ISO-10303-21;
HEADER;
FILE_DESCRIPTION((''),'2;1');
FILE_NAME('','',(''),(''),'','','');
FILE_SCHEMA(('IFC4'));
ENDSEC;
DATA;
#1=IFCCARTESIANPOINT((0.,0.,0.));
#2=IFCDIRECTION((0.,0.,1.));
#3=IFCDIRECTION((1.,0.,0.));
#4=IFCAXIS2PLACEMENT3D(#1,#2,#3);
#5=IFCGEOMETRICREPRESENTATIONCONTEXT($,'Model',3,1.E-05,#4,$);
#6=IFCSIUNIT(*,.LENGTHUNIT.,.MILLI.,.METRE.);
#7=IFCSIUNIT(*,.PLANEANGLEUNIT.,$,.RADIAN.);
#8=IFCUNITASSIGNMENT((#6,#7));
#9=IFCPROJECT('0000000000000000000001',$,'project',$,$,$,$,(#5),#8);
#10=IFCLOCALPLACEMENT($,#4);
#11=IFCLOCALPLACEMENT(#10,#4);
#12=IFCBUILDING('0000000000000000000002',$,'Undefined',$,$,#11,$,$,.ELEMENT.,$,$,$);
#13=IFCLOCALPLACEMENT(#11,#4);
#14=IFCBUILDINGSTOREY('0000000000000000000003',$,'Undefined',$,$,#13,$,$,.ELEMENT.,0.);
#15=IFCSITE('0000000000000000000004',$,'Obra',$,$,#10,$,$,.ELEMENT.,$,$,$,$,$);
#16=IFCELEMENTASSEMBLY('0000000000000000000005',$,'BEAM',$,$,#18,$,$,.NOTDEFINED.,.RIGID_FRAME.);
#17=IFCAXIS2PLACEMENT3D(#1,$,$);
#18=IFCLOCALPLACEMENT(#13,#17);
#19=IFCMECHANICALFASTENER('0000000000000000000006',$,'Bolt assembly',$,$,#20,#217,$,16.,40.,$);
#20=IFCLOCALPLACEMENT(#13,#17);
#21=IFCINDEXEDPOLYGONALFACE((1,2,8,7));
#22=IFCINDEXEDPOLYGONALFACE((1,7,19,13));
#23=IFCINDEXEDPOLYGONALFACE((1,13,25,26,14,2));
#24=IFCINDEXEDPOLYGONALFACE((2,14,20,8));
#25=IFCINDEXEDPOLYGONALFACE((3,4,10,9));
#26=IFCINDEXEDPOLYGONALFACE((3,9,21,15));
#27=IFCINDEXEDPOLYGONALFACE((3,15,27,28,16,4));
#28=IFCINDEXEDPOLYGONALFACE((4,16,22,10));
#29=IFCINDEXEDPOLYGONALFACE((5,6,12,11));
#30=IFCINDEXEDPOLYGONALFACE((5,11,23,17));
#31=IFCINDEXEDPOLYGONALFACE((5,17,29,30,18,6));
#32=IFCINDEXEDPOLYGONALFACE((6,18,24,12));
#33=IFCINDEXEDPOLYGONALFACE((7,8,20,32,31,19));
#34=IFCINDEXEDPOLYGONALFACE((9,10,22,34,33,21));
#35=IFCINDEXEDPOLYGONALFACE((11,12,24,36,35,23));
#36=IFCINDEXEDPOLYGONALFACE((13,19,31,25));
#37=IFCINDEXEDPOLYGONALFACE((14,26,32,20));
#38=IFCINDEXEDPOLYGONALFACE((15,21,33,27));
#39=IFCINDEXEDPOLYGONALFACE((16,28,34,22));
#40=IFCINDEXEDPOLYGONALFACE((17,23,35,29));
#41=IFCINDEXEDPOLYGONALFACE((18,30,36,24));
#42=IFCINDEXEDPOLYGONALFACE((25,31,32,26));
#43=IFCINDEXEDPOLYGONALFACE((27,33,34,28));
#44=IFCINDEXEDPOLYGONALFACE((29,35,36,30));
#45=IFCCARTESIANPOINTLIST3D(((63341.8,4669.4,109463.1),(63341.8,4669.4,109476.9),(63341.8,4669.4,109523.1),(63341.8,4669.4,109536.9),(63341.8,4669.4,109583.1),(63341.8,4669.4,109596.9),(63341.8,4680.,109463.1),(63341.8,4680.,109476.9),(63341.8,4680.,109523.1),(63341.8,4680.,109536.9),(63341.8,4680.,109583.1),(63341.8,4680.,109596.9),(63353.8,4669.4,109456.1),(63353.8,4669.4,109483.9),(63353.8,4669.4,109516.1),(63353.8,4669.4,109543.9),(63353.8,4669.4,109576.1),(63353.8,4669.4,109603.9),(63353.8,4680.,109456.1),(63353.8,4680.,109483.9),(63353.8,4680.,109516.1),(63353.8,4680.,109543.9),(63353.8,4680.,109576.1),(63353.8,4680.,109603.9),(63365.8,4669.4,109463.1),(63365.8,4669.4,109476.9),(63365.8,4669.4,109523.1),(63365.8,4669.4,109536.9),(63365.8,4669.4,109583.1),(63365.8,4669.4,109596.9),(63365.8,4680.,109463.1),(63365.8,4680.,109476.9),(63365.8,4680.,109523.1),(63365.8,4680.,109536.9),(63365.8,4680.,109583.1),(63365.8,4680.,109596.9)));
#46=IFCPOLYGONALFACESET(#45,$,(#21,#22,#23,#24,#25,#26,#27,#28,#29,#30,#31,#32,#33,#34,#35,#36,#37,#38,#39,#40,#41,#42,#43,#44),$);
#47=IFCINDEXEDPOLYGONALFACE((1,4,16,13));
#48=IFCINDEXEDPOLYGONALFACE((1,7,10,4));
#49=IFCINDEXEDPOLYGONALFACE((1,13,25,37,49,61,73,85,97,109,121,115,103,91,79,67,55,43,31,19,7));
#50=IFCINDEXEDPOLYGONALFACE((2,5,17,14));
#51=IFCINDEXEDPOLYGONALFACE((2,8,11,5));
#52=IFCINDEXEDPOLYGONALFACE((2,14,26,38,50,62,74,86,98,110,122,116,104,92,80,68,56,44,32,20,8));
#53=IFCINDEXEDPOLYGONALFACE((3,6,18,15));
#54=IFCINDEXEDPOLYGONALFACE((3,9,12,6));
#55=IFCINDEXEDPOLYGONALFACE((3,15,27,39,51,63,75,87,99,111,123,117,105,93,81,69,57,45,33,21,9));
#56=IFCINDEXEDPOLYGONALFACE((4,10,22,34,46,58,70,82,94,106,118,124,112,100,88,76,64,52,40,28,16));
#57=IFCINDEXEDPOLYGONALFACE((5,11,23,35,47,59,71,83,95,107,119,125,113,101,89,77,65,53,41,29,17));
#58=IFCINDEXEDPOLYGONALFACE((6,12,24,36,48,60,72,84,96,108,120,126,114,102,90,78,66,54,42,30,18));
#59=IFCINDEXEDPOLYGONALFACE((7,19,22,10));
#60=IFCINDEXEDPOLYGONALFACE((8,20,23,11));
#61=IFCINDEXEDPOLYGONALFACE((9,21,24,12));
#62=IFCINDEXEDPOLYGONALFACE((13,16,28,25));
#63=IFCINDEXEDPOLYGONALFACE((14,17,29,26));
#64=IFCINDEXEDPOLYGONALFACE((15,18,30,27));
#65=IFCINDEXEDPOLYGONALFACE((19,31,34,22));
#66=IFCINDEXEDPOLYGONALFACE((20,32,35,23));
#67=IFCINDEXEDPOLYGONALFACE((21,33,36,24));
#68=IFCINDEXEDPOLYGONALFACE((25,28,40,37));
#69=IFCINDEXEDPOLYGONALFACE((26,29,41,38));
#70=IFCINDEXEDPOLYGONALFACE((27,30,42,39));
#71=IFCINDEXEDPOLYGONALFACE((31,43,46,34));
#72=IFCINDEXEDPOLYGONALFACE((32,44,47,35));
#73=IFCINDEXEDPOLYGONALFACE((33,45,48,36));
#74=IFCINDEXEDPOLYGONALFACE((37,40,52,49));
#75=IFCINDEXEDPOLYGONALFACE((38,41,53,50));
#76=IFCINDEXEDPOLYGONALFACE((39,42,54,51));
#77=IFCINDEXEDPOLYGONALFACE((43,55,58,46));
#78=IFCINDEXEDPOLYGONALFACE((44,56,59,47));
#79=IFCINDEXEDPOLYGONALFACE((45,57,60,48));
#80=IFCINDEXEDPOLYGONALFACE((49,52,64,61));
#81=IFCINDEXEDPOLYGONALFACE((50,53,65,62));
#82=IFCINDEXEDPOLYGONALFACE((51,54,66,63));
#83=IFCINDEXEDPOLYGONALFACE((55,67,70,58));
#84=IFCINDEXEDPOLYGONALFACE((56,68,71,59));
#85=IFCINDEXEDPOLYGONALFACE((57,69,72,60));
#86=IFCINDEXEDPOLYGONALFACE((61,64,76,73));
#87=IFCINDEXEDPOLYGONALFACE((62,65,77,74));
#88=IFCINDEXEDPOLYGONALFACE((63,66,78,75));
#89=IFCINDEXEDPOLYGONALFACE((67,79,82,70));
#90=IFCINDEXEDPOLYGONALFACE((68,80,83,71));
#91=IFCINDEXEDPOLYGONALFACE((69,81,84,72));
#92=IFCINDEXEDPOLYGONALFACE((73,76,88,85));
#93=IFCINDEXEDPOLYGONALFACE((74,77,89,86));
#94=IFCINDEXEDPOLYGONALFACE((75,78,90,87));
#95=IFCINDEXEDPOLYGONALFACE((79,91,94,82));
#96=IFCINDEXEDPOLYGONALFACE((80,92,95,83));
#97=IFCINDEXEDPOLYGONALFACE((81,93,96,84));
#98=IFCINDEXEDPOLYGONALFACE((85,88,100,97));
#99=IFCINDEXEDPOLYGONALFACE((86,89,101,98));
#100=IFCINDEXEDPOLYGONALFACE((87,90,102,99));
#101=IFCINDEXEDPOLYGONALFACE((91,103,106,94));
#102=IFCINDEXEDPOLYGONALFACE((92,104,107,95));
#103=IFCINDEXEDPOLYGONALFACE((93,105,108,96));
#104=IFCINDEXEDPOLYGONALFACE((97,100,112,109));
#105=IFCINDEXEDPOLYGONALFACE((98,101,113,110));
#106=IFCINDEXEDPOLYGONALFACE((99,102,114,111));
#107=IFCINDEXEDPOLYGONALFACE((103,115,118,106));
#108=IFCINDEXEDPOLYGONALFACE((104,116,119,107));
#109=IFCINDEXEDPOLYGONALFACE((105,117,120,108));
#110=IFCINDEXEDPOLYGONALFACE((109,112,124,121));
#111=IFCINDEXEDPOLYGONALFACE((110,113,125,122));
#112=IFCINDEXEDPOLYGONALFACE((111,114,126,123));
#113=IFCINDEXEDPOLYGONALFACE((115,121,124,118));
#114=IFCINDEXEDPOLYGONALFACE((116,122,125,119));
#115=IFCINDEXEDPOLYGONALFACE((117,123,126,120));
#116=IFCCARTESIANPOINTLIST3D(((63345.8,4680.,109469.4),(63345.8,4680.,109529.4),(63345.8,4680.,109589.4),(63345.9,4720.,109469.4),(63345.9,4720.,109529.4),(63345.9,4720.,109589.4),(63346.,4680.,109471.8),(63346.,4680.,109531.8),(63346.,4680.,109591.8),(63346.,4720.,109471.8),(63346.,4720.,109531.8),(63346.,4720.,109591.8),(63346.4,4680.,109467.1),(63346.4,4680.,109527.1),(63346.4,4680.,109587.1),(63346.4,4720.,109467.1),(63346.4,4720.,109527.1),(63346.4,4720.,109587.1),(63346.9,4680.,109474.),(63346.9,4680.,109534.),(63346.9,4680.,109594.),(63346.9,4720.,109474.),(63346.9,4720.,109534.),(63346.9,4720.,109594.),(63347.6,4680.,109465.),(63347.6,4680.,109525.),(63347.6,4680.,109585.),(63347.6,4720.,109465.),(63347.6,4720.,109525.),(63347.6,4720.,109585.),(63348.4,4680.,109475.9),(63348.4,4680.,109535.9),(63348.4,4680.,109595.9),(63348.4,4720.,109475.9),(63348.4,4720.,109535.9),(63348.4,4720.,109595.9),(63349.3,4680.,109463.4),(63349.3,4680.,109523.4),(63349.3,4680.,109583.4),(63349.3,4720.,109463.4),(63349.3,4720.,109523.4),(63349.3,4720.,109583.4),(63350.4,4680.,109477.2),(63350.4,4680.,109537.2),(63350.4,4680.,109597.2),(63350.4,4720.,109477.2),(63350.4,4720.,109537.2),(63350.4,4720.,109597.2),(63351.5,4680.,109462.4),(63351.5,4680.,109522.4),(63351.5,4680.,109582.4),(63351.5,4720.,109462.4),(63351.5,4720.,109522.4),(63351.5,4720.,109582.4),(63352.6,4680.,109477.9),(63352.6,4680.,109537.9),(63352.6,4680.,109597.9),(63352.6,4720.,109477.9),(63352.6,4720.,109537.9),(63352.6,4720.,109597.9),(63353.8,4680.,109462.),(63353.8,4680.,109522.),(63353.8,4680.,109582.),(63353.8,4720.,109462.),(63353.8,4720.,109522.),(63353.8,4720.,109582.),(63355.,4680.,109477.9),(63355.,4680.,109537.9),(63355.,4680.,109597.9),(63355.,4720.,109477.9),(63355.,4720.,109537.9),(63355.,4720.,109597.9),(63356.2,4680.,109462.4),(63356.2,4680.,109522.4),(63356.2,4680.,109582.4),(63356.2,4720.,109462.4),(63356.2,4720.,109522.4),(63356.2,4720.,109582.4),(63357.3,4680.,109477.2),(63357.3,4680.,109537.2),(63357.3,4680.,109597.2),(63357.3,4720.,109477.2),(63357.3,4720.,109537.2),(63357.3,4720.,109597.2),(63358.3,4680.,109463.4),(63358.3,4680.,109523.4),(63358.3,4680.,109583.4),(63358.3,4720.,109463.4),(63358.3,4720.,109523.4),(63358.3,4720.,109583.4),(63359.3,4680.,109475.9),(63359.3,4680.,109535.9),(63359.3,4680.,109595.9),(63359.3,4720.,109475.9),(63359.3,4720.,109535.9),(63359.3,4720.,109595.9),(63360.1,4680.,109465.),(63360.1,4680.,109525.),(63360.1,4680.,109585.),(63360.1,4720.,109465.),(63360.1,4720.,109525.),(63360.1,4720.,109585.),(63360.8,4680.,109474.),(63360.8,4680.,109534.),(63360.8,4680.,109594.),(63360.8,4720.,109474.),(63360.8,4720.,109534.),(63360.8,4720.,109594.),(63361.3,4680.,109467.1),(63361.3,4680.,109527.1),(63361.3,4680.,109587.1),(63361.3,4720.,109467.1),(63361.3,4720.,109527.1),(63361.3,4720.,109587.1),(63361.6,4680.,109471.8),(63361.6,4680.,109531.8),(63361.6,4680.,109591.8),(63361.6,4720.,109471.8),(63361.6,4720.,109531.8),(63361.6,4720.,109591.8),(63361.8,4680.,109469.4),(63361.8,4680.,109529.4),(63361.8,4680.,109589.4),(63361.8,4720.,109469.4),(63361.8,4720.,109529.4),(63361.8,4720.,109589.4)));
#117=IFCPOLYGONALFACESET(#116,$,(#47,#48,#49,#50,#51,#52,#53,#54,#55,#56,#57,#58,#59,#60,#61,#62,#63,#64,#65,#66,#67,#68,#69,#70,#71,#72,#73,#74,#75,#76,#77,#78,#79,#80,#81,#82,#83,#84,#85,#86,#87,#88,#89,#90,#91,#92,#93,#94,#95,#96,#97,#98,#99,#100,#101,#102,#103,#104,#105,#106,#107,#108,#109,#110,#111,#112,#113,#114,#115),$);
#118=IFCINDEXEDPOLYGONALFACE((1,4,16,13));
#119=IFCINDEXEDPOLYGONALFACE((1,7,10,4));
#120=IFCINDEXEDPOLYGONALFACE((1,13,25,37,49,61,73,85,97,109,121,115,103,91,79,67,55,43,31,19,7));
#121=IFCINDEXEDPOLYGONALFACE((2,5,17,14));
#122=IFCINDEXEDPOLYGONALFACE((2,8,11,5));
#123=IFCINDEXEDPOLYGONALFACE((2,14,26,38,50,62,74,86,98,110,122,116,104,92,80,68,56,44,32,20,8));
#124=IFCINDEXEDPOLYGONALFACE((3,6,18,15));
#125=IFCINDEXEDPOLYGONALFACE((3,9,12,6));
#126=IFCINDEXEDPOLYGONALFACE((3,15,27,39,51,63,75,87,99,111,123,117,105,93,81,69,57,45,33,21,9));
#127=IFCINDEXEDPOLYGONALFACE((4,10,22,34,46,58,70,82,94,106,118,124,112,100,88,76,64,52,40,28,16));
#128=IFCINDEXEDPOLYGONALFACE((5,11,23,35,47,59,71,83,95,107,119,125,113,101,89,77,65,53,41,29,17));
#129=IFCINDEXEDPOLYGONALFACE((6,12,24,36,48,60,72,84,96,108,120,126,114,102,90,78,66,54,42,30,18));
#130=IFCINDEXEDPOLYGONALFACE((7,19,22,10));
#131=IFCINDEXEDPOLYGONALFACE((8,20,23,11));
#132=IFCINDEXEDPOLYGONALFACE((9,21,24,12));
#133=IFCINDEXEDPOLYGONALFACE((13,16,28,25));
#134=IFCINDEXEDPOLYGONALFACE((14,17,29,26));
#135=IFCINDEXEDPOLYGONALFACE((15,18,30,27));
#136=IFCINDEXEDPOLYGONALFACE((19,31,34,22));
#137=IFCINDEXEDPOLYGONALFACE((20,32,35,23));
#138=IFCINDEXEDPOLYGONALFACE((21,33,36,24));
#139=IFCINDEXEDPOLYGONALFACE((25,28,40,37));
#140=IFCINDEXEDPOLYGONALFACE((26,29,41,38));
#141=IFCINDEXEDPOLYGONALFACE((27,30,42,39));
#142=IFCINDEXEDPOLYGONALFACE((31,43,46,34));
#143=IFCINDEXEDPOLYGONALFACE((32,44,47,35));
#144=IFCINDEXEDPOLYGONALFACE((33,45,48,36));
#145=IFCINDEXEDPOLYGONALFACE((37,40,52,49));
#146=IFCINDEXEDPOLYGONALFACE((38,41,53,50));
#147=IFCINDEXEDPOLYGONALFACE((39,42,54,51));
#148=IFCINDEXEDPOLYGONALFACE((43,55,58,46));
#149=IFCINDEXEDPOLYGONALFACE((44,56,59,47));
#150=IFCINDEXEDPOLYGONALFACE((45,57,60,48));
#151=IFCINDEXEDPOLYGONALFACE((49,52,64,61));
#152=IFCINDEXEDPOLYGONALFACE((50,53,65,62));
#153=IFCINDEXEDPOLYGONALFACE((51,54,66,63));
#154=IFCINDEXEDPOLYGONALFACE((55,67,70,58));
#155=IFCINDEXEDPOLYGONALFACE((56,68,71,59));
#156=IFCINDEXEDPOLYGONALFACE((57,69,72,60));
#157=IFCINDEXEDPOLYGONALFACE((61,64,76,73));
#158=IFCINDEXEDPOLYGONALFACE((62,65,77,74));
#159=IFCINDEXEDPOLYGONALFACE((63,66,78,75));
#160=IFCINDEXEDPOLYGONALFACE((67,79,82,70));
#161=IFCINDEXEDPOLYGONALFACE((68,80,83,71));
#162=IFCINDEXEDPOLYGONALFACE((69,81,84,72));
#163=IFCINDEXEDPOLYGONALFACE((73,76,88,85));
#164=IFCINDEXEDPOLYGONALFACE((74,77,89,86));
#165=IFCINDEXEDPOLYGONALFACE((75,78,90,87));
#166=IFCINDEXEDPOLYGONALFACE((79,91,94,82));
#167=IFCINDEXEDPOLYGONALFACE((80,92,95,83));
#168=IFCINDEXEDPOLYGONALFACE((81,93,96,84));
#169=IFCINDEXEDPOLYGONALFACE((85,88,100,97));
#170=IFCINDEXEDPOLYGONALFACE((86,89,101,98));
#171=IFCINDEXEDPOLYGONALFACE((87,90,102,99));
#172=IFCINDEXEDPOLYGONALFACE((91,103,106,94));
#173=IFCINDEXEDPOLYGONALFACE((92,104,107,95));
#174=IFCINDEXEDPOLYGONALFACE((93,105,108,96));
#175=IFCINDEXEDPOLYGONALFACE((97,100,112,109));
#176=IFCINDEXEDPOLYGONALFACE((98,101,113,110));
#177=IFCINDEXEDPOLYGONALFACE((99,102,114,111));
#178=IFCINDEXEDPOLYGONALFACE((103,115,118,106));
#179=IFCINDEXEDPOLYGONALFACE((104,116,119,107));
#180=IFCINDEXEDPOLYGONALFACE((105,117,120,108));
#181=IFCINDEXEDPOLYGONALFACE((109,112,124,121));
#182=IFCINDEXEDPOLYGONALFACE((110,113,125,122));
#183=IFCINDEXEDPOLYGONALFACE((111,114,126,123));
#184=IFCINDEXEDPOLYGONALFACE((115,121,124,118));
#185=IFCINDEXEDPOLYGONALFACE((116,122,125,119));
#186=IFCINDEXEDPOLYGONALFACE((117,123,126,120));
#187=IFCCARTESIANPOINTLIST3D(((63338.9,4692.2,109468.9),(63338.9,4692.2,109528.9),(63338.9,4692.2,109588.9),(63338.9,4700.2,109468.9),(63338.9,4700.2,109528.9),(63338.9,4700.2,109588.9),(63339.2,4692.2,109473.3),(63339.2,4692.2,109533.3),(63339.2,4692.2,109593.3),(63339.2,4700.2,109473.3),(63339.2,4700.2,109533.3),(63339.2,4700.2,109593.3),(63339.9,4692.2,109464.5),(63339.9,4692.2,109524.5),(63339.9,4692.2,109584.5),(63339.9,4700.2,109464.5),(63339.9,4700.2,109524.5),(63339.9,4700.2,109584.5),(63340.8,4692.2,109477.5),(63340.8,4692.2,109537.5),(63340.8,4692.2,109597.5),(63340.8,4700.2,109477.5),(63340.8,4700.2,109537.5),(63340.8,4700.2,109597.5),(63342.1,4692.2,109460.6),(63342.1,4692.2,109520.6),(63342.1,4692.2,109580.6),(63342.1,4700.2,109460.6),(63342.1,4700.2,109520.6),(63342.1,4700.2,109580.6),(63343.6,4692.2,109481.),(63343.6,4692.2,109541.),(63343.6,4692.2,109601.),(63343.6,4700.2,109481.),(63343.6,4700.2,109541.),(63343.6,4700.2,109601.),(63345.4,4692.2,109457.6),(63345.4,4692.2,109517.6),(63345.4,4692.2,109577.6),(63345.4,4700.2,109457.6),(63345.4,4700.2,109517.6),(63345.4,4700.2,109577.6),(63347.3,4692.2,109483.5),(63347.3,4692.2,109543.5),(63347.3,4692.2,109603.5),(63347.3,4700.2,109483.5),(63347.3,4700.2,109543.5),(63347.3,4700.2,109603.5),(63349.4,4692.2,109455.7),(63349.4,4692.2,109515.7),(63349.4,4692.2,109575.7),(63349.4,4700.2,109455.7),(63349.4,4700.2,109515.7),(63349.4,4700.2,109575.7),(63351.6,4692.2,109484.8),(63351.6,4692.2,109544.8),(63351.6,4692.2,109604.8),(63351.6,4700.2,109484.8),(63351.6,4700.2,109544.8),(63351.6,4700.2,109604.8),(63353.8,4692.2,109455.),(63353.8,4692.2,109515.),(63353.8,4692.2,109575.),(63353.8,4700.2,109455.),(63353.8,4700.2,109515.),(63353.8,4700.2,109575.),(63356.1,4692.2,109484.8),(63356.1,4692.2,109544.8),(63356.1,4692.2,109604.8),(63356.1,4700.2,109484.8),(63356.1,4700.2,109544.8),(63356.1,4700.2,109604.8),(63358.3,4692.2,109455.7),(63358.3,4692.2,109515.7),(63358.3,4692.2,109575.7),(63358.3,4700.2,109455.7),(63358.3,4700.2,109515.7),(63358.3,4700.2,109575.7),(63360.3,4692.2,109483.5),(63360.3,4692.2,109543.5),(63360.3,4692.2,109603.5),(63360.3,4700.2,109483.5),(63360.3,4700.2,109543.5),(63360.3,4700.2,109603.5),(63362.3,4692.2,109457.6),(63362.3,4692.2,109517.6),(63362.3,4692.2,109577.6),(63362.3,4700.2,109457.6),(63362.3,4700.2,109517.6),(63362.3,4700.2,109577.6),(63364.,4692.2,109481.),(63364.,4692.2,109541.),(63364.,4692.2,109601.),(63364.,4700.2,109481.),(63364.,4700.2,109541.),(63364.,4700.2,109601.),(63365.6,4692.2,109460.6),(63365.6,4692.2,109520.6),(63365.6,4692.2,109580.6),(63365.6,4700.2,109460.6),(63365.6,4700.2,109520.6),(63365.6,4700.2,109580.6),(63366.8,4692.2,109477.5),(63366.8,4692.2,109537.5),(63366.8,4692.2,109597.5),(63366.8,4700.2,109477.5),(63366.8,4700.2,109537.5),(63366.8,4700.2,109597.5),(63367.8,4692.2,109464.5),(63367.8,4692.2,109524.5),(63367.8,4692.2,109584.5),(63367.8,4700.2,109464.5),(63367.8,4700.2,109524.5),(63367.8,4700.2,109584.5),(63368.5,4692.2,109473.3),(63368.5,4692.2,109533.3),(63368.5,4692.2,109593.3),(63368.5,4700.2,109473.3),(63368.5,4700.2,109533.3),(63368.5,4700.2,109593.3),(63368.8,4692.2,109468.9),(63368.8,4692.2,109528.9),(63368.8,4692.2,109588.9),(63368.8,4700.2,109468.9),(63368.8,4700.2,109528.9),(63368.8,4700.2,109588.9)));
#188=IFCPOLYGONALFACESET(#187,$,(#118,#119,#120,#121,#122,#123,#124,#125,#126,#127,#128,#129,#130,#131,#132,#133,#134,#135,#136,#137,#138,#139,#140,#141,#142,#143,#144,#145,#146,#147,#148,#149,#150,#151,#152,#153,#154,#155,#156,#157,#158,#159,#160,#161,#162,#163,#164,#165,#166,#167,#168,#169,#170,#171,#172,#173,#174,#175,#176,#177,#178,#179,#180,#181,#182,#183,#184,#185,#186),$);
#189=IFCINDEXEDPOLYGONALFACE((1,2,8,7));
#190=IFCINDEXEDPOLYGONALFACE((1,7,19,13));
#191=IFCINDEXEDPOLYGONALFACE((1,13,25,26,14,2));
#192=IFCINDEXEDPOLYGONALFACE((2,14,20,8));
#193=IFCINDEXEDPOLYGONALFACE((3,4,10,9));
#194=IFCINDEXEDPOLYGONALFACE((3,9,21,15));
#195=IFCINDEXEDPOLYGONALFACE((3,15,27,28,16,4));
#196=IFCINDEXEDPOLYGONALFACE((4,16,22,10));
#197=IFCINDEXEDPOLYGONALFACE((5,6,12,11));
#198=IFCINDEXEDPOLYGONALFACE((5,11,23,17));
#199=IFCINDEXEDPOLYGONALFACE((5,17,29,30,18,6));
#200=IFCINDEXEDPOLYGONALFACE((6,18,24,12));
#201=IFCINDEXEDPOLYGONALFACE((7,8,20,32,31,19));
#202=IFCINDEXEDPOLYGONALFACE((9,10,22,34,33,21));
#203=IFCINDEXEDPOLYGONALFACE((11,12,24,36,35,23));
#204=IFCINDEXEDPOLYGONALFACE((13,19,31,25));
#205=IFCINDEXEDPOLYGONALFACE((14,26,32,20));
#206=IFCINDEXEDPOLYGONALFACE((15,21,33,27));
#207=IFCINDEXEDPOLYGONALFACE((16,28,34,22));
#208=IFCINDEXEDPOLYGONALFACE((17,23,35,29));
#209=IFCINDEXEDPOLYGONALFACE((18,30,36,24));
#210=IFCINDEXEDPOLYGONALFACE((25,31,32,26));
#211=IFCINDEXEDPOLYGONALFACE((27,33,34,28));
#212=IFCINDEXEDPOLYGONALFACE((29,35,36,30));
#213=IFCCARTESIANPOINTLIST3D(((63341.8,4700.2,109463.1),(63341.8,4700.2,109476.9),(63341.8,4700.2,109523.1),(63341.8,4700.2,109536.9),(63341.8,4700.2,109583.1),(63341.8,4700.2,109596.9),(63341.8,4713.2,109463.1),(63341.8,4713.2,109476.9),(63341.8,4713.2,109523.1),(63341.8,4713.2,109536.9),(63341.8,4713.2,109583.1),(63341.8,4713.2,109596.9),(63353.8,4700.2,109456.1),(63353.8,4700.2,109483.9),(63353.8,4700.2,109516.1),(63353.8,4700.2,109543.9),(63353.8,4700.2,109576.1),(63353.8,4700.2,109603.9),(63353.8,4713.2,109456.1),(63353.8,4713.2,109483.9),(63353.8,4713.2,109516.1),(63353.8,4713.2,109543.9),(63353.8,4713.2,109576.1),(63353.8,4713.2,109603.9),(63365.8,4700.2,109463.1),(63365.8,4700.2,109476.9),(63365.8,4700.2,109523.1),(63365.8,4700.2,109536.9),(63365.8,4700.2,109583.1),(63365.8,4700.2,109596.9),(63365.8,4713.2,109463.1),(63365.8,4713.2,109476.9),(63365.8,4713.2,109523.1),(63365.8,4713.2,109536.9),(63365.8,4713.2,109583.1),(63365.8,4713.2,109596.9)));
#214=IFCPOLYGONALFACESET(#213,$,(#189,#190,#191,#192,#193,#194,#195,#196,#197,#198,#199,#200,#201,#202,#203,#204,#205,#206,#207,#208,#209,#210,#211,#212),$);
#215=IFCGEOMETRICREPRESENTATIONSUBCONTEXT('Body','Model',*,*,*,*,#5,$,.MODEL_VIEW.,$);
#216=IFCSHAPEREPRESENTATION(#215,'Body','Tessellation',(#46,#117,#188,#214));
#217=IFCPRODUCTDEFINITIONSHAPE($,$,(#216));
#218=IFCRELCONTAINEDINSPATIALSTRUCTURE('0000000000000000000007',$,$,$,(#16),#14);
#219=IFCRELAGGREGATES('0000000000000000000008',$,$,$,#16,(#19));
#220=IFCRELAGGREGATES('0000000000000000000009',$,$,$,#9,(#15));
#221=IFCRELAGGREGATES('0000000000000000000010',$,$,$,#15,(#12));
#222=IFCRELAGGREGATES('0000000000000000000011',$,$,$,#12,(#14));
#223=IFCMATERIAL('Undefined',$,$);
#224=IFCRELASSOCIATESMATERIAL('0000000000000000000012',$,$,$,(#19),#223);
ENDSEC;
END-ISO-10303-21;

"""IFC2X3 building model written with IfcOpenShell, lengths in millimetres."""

from ifc_helpers import new_model, si_unit, frame, origin_with_axes, origin_2d_with_axis, place, context, subcontext, project, spatial, polyline, circle, outline, extrude, source, transform, mapped, material, element, aggregate, save


model = new_model("IFC2X3")

# Units and contexts
model_context = context("Model", 3, precision=1e-05, world=origin_with_axes())
body_context = subcontext(model_context, "Body", "Model", "MODEL_VIEW")
ifc_project = project(units=[si_unit("LENGTHUNIT", "METRE", prefix="MILLI"), si_unit("PLANEANGLEUNIT", "RADIAN")], contexts=[model_context])

# Site, building, storey
site_placement = place(None, origin_with_axes())
site = spatial("IfcSite", under=ifc_project, at=site_placement, Name="Obra", CompositionType="ELEMENT")
building_placement = place(site_placement, origin_with_axes())
building = spatial("IfcBuilding", under=site, at=building_placement, Name="Undefined", CompositionType="ELEMENT")
storey_placement = place(building_placement, origin_with_axes())
storey = spatial("IfcBuildingStorey", under=building, at=storey_placement, Name="Undefined", CompositionType="ELEMENT", Elevation=0.0)

# Element assembly
assembly_1_placement = place(storey_placement, origin_with_axes())
assembly_1 = element("IfcElementAssembly", 1, at=assembly_1_placement, inside=storey, Name="BEAM", AssemblyPlace="NOTDEFINED", PredefinedType="RIGID_FRAME")

# Mechanical fastener
ifc_material_1 = material(Name="Undefined")
shared_shape_1 = source(origin_with_axes(), body_context, "Body", "SweptSolid", [
    extrude(outline(polyline([(13.9, 0.0), (6.9, 12.0), (-6.9, 12.0), (-13.9, 0.0), (-6.9, -12.0), (6.9, -12.0), (13.9, 0.0)])), frame((0.0, -19.7, 0.0), z_axis=(0.0, 1.0, 0.0), x_axis=(1.0, 0.0, 0.0)), (0.0, 0.0, 1.0), 10.6),
    extrude(circle(Radius=8.0, at=origin_2d_with_axis()), frame((0.0, -9.1, 0.0), z_axis=(0.0, 1.0, 0.0), x_axis=(1.0, 0.0, 0.0)), (0.0, 0.0, 1.0), 40.0),
    extrude(circle(Radius=15.0, at=origin_2d_with_axis()), frame((0.0, 3.1, 0.0), z_axis=(0.0, 1.0, 0.0), x_axis=(1.0, 0.0, 0.0)), (0.0, 0.0, 1.0), 8.0),
    extrude(outline(polyline([(13.9, 0.0), (6.9, 12.0), (-6.9, 12.0), (-13.9, 0.0), (-6.9, -12.0), (6.9, -12.0), (13.9, 0.0)])), frame((0.0, 11.1, 0.0), z_axis=(0.0, 1.0, 0.0), x_axis=(1.0, 0.0, 0.0)), (0.0, 0.0, 1.0), 13.0),
])
mechanical_fastener_1_placement = place(assembly_1_placement, frame((63303.8, 4689.1, 109650.0), z_axis=(1.0, -0.000126, 0.0), x_axis=(0.0, 0.0, -1.0)))
mechanical_fastener_1 = element("IfcMechanicalFastener", 2, at=mechanical_fastener_1_placement, material=ifc_material_1, Name="Bolt assembly", NominalDiameter=16.0, NominalLength=40.0, context=body_context, shape_type="MappedRepresentation", body=[
    mapped(shared_shape_1, transform((60.0, 0.0, 50.0))),
    mapped(shared_shape_1, transform((120.0, 0.0, 50.0))),
    mapped(shared_shape_1, transform((180.0, 0.0, 50.0))),
])
aggregate(assembly_1, [mechanical_fastener_1])

save(model, "model.ifc")
